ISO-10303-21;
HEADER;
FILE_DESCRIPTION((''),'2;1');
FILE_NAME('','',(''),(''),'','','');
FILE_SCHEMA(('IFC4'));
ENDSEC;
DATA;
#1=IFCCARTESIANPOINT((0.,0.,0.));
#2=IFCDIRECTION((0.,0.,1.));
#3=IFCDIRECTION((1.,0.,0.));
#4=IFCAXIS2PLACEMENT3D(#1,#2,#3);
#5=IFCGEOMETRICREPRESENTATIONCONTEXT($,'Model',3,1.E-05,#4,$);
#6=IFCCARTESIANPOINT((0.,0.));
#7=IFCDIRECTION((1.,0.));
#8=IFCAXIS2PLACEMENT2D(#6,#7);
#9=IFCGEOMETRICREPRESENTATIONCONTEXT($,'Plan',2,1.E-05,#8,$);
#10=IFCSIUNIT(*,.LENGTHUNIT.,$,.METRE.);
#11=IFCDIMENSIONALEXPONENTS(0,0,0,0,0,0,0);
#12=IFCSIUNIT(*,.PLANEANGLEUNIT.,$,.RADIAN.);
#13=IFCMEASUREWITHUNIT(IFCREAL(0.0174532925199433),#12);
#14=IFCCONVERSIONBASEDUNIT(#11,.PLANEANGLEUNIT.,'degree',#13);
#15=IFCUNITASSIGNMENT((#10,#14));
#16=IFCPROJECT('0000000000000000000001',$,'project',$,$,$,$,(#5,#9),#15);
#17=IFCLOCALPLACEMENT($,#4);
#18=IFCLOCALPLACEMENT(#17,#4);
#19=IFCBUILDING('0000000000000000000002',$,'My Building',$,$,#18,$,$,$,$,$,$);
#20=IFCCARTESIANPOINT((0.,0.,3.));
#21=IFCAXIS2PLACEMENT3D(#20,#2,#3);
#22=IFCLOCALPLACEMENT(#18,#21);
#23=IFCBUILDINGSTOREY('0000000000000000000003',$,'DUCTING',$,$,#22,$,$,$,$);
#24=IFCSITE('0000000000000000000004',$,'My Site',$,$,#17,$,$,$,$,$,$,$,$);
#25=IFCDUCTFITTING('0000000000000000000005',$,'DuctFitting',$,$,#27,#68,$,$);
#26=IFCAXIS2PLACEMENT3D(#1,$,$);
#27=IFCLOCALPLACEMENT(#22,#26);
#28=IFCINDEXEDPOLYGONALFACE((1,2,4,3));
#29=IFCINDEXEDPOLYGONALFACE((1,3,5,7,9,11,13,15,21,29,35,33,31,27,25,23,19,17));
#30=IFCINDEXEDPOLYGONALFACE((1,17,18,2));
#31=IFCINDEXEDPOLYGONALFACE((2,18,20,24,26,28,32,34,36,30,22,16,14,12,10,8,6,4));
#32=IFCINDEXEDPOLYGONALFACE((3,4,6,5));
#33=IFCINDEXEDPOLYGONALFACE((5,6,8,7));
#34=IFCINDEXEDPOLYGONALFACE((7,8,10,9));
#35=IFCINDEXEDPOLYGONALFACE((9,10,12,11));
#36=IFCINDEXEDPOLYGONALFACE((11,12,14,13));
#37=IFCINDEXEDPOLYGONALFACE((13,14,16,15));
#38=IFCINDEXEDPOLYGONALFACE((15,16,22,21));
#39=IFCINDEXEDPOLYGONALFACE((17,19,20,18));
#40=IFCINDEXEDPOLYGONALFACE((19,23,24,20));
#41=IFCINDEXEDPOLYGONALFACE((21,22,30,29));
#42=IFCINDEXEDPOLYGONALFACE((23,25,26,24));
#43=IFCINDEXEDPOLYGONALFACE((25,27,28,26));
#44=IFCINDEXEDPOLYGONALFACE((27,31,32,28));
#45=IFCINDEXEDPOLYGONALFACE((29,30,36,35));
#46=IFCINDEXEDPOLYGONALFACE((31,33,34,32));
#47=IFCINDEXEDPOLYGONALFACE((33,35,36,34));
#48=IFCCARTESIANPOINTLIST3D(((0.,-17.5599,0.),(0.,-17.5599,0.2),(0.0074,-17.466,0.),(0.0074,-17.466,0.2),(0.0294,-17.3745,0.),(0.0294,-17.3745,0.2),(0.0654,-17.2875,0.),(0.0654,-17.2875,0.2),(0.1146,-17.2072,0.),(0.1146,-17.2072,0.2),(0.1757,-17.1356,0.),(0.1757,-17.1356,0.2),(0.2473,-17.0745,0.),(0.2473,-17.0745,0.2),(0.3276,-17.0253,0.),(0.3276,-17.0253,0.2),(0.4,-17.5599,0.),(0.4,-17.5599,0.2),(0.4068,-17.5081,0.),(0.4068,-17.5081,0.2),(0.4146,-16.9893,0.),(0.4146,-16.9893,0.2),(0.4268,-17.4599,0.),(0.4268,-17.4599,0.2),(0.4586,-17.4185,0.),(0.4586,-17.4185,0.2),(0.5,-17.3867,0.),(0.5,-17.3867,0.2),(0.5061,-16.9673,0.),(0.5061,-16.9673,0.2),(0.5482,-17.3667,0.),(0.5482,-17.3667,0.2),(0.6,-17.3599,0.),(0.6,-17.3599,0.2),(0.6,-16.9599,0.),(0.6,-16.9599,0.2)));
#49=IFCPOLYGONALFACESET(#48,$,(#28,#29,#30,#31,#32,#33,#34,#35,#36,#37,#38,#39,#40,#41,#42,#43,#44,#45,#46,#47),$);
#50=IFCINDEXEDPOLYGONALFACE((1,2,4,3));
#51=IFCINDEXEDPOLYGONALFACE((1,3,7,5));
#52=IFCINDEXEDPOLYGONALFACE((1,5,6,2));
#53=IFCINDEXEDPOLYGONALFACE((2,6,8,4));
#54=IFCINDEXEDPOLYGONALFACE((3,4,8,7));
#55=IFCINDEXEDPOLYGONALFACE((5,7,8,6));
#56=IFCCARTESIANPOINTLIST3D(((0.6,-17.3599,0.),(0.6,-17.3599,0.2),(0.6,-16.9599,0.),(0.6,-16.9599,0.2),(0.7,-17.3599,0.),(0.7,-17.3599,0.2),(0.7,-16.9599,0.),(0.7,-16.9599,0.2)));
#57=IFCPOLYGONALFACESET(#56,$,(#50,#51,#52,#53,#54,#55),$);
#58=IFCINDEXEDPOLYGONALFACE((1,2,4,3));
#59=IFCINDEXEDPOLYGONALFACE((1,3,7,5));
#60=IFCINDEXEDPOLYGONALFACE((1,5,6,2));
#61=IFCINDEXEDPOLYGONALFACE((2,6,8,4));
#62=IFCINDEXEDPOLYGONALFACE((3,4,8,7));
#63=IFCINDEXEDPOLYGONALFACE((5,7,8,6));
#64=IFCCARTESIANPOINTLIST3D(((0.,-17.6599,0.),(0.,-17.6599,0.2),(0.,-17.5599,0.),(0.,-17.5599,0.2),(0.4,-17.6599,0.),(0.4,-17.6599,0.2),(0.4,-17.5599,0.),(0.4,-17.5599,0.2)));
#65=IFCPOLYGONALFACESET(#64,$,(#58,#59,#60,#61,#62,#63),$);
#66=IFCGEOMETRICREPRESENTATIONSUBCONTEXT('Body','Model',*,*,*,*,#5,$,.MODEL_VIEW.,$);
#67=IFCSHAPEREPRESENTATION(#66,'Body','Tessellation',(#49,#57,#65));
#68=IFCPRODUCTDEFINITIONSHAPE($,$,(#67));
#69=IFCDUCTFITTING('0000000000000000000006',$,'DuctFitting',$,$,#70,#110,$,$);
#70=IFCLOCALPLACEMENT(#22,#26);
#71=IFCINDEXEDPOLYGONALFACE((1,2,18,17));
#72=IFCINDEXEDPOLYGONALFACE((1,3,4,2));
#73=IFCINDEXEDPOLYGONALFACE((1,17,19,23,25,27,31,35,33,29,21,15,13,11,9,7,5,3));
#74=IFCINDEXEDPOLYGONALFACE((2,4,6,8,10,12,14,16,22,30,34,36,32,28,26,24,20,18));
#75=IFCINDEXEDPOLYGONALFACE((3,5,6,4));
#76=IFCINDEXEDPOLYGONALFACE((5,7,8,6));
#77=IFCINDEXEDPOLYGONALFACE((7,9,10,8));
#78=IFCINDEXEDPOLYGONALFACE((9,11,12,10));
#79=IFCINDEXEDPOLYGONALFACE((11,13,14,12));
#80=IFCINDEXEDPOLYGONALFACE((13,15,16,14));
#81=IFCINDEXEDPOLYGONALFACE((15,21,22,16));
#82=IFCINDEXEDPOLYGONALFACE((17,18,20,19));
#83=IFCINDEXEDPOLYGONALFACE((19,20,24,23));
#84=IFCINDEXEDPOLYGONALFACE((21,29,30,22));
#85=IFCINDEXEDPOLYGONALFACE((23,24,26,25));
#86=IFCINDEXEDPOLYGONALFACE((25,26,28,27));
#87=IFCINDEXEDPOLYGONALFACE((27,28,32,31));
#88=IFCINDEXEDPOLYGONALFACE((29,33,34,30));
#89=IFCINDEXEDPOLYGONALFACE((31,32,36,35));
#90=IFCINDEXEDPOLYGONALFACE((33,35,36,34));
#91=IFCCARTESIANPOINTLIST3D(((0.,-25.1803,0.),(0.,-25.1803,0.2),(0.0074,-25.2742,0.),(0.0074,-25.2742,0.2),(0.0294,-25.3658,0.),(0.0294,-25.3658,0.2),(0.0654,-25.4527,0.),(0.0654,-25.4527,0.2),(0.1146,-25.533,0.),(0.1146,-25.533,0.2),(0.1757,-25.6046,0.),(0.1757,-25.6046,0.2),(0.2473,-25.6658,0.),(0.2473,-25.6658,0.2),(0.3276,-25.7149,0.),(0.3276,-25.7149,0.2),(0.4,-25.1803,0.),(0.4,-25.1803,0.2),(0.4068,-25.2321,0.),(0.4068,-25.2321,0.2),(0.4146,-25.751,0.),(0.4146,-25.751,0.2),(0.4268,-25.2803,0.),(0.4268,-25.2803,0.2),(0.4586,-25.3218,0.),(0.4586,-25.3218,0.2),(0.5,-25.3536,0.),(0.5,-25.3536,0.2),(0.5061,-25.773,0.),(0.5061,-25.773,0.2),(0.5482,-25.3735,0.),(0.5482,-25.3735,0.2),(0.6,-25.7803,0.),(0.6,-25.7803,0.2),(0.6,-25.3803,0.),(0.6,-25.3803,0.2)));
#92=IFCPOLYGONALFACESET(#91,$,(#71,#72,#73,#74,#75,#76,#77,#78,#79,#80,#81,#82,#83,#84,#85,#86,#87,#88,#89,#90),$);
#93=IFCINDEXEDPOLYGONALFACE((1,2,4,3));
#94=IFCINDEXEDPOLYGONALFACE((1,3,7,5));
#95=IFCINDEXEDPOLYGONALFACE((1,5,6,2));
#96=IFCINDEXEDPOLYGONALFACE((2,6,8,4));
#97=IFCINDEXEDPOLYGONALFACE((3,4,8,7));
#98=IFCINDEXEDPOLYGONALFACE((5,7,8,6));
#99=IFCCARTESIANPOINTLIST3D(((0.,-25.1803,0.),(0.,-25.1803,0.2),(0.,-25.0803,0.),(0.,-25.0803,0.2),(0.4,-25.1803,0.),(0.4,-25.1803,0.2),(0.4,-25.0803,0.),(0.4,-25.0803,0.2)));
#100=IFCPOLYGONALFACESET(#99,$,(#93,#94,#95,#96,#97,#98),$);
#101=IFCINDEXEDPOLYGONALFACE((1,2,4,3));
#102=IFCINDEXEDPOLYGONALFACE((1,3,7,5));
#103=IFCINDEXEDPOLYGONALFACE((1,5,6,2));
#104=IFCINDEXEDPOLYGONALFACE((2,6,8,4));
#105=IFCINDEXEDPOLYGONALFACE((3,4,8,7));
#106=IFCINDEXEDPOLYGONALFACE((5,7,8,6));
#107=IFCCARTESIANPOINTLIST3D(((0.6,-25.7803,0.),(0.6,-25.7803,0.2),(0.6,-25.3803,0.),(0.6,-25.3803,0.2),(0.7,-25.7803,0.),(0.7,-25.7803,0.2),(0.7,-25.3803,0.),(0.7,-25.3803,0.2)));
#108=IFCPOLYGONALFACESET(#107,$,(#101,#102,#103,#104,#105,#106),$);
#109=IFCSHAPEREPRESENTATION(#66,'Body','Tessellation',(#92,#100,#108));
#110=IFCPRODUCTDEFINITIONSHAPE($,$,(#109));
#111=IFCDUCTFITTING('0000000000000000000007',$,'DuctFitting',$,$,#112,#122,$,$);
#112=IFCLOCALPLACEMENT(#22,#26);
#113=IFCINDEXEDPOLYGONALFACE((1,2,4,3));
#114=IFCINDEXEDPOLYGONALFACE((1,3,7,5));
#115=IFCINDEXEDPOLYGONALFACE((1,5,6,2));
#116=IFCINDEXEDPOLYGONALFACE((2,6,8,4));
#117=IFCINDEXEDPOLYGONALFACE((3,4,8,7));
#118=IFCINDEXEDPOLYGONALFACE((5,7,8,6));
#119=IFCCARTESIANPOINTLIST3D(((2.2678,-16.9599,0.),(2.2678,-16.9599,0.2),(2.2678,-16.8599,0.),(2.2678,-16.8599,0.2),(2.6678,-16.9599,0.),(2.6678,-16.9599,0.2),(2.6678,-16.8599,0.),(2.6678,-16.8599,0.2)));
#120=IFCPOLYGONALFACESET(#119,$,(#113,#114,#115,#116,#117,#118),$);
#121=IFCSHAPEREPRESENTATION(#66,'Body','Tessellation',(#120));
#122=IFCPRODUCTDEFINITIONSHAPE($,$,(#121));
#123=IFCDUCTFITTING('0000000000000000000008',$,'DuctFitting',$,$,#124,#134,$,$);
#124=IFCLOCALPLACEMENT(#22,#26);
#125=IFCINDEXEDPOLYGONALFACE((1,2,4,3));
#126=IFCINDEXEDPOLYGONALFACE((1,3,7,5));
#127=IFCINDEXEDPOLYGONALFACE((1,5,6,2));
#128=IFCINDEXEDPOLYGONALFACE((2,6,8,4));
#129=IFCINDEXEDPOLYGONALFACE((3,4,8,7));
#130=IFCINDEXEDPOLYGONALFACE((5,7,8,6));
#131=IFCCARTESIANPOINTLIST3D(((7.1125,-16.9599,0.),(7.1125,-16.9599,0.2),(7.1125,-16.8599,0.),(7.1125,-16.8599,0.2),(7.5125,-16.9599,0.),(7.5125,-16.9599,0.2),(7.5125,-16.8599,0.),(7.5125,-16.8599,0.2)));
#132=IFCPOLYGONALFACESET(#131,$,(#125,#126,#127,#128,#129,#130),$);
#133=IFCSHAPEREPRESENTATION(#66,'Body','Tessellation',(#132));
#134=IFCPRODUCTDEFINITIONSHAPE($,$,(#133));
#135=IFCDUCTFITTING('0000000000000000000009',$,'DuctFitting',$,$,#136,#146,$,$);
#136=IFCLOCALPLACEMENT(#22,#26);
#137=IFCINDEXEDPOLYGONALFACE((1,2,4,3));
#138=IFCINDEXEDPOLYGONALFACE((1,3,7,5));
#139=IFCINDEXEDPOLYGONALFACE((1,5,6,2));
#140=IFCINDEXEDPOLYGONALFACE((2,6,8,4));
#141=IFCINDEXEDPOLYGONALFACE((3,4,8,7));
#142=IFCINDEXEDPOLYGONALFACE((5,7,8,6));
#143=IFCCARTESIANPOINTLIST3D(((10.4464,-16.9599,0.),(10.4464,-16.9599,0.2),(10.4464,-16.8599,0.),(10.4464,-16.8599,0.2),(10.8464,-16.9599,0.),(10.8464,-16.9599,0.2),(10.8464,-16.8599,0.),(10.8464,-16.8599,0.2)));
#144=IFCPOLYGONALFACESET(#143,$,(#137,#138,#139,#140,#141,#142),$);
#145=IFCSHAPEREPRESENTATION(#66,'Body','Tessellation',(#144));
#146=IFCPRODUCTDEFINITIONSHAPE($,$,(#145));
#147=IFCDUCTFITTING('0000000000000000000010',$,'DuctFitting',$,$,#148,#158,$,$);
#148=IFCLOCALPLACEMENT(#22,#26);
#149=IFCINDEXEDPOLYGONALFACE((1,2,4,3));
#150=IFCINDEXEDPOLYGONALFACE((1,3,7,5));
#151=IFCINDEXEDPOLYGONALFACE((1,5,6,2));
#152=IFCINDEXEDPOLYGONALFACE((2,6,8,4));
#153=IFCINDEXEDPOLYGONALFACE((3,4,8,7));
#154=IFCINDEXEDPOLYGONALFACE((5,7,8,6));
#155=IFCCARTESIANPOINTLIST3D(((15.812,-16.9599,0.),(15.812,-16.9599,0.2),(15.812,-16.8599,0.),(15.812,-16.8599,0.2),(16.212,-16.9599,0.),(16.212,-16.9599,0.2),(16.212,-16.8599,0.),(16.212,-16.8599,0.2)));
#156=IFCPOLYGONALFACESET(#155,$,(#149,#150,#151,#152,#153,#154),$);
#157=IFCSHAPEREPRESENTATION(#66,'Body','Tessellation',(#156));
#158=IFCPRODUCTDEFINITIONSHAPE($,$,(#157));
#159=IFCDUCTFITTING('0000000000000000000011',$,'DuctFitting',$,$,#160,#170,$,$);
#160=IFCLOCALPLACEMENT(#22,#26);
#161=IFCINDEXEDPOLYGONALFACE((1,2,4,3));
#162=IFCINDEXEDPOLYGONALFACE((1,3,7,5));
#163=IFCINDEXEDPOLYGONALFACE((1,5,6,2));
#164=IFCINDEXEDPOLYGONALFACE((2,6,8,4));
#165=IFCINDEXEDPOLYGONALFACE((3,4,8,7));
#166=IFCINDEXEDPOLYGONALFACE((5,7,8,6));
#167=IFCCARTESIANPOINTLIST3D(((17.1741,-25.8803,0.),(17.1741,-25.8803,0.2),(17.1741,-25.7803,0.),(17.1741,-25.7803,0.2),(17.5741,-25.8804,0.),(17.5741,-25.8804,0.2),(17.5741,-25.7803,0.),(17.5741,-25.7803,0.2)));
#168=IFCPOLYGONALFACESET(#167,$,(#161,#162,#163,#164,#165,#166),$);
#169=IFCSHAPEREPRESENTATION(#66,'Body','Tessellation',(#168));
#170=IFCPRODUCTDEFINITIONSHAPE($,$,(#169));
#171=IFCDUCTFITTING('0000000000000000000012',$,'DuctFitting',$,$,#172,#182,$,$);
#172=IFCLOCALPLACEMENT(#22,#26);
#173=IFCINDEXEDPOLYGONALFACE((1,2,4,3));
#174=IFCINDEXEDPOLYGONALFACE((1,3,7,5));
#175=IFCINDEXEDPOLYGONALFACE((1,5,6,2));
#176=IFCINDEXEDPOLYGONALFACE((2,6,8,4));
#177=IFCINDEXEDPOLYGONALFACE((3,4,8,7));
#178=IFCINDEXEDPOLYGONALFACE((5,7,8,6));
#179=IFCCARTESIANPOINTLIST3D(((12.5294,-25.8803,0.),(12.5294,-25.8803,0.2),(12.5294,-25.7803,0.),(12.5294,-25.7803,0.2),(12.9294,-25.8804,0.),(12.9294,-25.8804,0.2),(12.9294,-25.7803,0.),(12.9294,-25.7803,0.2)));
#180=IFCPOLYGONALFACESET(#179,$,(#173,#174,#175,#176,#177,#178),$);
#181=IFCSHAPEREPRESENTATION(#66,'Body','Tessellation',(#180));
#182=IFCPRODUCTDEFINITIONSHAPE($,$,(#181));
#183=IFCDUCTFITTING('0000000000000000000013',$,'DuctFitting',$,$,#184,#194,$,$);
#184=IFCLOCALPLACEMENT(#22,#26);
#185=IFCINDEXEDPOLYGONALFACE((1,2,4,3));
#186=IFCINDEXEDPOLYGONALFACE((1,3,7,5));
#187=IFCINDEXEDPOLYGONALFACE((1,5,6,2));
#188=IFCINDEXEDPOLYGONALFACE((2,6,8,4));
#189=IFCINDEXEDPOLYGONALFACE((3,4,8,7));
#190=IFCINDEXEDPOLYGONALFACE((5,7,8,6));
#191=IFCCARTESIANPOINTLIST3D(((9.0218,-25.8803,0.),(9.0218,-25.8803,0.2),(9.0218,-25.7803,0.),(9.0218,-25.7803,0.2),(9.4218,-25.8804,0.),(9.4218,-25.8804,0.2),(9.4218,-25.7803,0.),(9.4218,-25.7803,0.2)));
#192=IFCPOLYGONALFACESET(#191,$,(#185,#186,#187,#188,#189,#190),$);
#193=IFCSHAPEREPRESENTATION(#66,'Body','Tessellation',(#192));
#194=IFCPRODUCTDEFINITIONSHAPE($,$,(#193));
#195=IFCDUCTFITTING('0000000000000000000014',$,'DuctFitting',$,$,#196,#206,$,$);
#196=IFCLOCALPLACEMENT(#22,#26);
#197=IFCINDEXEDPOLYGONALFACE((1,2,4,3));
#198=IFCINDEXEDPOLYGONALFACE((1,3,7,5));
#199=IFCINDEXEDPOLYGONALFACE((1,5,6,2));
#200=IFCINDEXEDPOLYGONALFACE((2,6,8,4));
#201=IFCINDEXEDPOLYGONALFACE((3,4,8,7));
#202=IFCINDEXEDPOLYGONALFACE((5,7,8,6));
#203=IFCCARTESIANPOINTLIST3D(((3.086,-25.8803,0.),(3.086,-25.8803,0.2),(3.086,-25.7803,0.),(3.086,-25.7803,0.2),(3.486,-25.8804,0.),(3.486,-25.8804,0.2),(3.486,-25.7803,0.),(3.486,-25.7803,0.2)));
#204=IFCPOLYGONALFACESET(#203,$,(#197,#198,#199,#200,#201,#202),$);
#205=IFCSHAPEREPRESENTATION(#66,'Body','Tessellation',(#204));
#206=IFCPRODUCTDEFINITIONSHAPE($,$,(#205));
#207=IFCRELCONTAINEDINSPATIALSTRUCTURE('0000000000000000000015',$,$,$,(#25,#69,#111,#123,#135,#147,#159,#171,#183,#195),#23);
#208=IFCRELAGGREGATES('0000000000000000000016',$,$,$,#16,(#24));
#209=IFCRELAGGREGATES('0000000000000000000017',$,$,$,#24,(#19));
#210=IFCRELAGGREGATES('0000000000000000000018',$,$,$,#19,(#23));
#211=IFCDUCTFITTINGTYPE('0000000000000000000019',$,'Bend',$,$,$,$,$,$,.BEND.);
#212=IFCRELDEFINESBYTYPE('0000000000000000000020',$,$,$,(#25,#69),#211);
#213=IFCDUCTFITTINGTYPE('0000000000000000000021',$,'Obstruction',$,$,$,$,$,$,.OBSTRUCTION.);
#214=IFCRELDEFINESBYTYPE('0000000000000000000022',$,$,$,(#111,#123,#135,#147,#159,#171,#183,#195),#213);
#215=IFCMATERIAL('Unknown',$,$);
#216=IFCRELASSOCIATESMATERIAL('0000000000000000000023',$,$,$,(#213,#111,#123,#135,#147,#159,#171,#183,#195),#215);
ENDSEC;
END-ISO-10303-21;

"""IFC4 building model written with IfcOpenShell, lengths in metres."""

from ifc_helpers import new_model, entity, si_unit, converted_unit, frame, origin_with_axes, origin_2d_with_axis, place, context, subcontext, project, spatial, line, arc, indexed_curve, rectangle, outline, extrude, source, transform, mapped, material, material_profile, profile_set, profile_usage, type_object, type_shapes, element, save


model = new_model("IFC4")

# Units and contexts
model_context = context("Model", 3, precision=1e-05, world=origin_with_axes())
plan_context = context("Plan", 2, precision=1e-05, world=origin_2d_with_axis())
body_context = subcontext(model_context, "Body", "Model", "MODEL_VIEW")
ifc_project = project(units=[si_unit("LENGTHUNIT", "METRE"), converted_unit("PLANEANGLEUNIT", "degree", entity("IfcReal", 0.0174532925199433), si_unit("PLANEANGLEUNIT", "RADIAN"), dimensions=[0, 0, 0, 0, 0, 0, 0])], contexts=[model_context, plan_context])

# Site, building, storey
site_placement = place(None, origin_with_axes())
site = spatial("IfcSite", under=ifc_project, at=site_placement, Name="My Site")
building_placement = place(site_placement, origin_with_axes())
building = spatial("IfcBuilding", under=site, at=building_placement, Name="My Building")
storey_placement = place(building_placement, frame((0.0, 0.0, 3.0), z_axis=(0.0, 0.0, 1.0), x_axis=(1.0, 0.0, 0.0)))
storey = spatial("IfcBuildingStorey", under=building, at=storey_placement, Name="DUCTING")

# Shared definitions
ifc_material = material(Name="Unknown")

# Duct fittings
duct_fitting_type_1 = type_object("IfcDuctFittingType", Name="Bend", PredefinedType="BEND")
shared_shape = source(origin_with_axes(), body_context, "Body", "SweptSolid", [
    extrude(outline(indexed_curve([(0.2, 0.0), (0.2586, 0.1414), (0.4, 0.2), (0.4, 0.6), (-0.0243, 0.4243), (-0.2, 0.0)], segments=[arc(1, 2, 3), line(3, 4), arc(4, 5, 6), line(6, 1)])), frame((0.0, -0.1, 0.1), z_axis=(0.0, -1.0, 0.0), x_axis=(1.0, 0.0, 0.0)), (0.0, 0.0, -1.0), 0.2),
    extrude(rectangle(XDim=0.4, YDim=0.2), origin_with_axes(), (0.0, 0.0, 1.0), 0.1),
    extrude(rectangle(XDim=0.4, YDim=0.2), frame((0.4, 0.0, 0.5), z_axis=(1.0, 0.0, 0.0), x_axis=(0.0, 0.0, 1.0)), (0.0, 0.0, 1.0), 0.1),
])
type_shapes(duct_fitting_type_1, [shared_shape])
for number, where, z_axis, x_axis, name in (
    (1, (0.7, -17.1599, 0.1), (-1.0, 0.0, 0.0), (0.0, -1.0, 0.0), "DuctFitting"),
    (2, (0.2, -25.0803, 0.1), (0.0, -1.0, 0.0), (1.0, 0.0, 0.0), "DuctFitting"),
):
    element("IfcDuctFitting", number, at=place(storey_placement, frame(where, z_axis=z_axis, x_axis=x_axis)), inside=storey, type_object=duct_fitting_type_1, Name=name, context=body_context, shape_type="MappedRepresentation", body=[
        mapped(shared_shape, transform((0.0, 0.0, 0.0), x_axis=(1.0, 0.0, 0.0), y_axis=(0.0, 1.0, 0.0), z_axis=(0.0, 0.0, 1.0), scale=1.0)),
    ])
ifc_material_profile_1 = material_profile(ifc_material, rectangle(XDim=0.4, YDim=0.2))
ifc_profile_set_1 = profile_set([ifc_material_profile_1])
ifc_profile_usage_1 = profile_usage(ifc_profile_set_1, cardinal=5)
duct_fitting_type_2 = type_object("IfcDuctFittingType", Name="Obstruction", PredefinedType="OBSTRUCTION", material=ifc_profile_set_1)
duct_fitting_1_placement = place(storey_placement, frame((2.4678, -16.8599, 0.1), z_axis=(0.0, -1.0, 0.0), x_axis=(1.0, 0.0, 0.0)))
element("IfcDuctFitting", 3, at=duct_fitting_1_placement, inside=storey, type_object=duct_fitting_type_2, material=ifc_profile_usage_1, Name="DuctFitting", context=body_context, shape_type="SweptSolid", body=[
    extrude(rectangle(XDim=0.4, YDim=0.2), origin_with_axes(), (0.0, 0.0, 1.0), 0.1),
])
ifc_profile_usage_2 = profile_usage(ifc_profile_set_1, cardinal=5)
duct_fitting_2_placement = place(storey_placement, frame((7.3125, -16.8599, 0.1), z_axis=(0.0, -1.0, 0.0), x_axis=(1.0, 0.0, 0.0)))
element("IfcDuctFitting", 4, at=duct_fitting_2_placement, inside=storey, type_object=duct_fitting_type_2, material=ifc_profile_usage_2, Name="DuctFitting", context=body_context, shape_type="SweptSolid", body=[
    extrude(rectangle(XDim=0.4, YDim=0.2), origin_with_axes(), (0.0, 0.0, 1.0), 0.1),
])
ifc_profile_usage_3 = profile_usage(ifc_profile_set_1, cardinal=5)
duct_fitting_3_placement = place(storey_placement, frame((10.6464, -16.8599, 0.1), z_axis=(0.0, -1.0, 0.0), x_axis=(1.0, 0.0, 0.0)))
element("IfcDuctFitting", 5, at=duct_fitting_3_placement, inside=storey, type_object=duct_fitting_type_2, material=ifc_profile_usage_3, Name="DuctFitting", context=body_context, shape_type="SweptSolid", body=[
    extrude(rectangle(XDim=0.4, YDim=0.2), origin_with_axes(), (0.0, 0.0, 1.0), 0.1),
])
ifc_profile_usage_4 = profile_usage(ifc_profile_set_1, cardinal=5)
duct_fitting_4_placement = place(storey_placement, frame((16.012, -16.8599, 0.1), z_axis=(0.0, -1.0, 0.0), x_axis=(1.0, 0.0, 0.0)))
element("IfcDuctFitting", 6, at=duct_fitting_4_placement, inside=storey, type_object=duct_fitting_type_2, material=ifc_profile_usage_4, Name="DuctFitting", context=body_context, shape_type="SweptSolid", body=[
    extrude(rectangle(XDim=0.4, YDim=0.2), origin_with_axes(), (0.0, 0.0, 1.0), 0.1),
])
ifc_profile_usage_5 = profile_usage(ifc_profile_set_1, cardinal=5)
duct_fitting_5_placement = place(storey_placement, frame((17.3741, -25.8804, 0.1), z_axis=(0.000001, 1.0, 0.0), x_axis=(-1.0, 0.000001, 0.0)))
element("IfcDuctFitting", 7, at=duct_fitting_5_placement, inside=storey, type_object=duct_fitting_type_2, material=ifc_profile_usage_5, Name="DuctFitting", context=body_context, shape_type="SweptSolid", body=[
    extrude(rectangle(XDim=0.4, YDim=0.2), origin_with_axes(), (0.0, 0.0, 1.0), 0.1),
])
ifc_profile_usage_6 = profile_usage(ifc_profile_set_1, cardinal=5)
duct_fitting_6_placement = place(storey_placement, frame((12.7294, -25.8804, 0.1), z_axis=(0.000001, 1.0, 0.0), x_axis=(-1.0, 0.000001, 0.0)))
element("IfcDuctFitting", 8, at=duct_fitting_6_placement, inside=storey, type_object=duct_fitting_type_2, material=ifc_profile_usage_6, Name="DuctFitting", context=body_context, shape_type="SweptSolid", body=[
    extrude(rectangle(XDim=0.4, YDim=0.2), origin_with_axes(), (0.0, 0.0, 1.0), 0.1),
])
ifc_profile_usage_7 = profile_usage(ifc_profile_set_1, cardinal=5)
duct_fitting_7_placement = place(storey_placement, frame((9.2218, -25.8804, 0.1), z_axis=(0.000001, 1.0, 0.0), x_axis=(-1.0, 0.000001, 0.0)))
element("IfcDuctFitting", 9, at=duct_fitting_7_placement, inside=storey, type_object=duct_fitting_type_2, material=ifc_profile_usage_7, Name="DuctFitting", context=body_context, shape_type="SweptSolid", body=[
    extrude(rectangle(XDim=0.4, YDim=0.2), origin_with_axes(), (0.0, 0.0, 1.0), 0.1),
])
ifc_profile_usage_8 = profile_usage(ifc_profile_set_1, cardinal=5)
duct_fitting_8_placement = place(storey_placement, frame((3.286, -25.8804, 0.1), z_axis=(0.000001, 1.0, 0.0), x_axis=(-1.0, 0.000001, 0.0)))
element("IfcDuctFitting", 10, at=duct_fitting_8_placement, inside=storey, type_object=duct_fitting_type_2, material=ifc_profile_usage_8, Name="DuctFitting", context=body_context, shape_type="SweptSolid", body=[
    extrude(rectangle(XDim=0.4, YDim=0.2), origin_with_axes(), (0.0, 0.0, 1.0), 0.1),
])

save(model, "model.ifc")
